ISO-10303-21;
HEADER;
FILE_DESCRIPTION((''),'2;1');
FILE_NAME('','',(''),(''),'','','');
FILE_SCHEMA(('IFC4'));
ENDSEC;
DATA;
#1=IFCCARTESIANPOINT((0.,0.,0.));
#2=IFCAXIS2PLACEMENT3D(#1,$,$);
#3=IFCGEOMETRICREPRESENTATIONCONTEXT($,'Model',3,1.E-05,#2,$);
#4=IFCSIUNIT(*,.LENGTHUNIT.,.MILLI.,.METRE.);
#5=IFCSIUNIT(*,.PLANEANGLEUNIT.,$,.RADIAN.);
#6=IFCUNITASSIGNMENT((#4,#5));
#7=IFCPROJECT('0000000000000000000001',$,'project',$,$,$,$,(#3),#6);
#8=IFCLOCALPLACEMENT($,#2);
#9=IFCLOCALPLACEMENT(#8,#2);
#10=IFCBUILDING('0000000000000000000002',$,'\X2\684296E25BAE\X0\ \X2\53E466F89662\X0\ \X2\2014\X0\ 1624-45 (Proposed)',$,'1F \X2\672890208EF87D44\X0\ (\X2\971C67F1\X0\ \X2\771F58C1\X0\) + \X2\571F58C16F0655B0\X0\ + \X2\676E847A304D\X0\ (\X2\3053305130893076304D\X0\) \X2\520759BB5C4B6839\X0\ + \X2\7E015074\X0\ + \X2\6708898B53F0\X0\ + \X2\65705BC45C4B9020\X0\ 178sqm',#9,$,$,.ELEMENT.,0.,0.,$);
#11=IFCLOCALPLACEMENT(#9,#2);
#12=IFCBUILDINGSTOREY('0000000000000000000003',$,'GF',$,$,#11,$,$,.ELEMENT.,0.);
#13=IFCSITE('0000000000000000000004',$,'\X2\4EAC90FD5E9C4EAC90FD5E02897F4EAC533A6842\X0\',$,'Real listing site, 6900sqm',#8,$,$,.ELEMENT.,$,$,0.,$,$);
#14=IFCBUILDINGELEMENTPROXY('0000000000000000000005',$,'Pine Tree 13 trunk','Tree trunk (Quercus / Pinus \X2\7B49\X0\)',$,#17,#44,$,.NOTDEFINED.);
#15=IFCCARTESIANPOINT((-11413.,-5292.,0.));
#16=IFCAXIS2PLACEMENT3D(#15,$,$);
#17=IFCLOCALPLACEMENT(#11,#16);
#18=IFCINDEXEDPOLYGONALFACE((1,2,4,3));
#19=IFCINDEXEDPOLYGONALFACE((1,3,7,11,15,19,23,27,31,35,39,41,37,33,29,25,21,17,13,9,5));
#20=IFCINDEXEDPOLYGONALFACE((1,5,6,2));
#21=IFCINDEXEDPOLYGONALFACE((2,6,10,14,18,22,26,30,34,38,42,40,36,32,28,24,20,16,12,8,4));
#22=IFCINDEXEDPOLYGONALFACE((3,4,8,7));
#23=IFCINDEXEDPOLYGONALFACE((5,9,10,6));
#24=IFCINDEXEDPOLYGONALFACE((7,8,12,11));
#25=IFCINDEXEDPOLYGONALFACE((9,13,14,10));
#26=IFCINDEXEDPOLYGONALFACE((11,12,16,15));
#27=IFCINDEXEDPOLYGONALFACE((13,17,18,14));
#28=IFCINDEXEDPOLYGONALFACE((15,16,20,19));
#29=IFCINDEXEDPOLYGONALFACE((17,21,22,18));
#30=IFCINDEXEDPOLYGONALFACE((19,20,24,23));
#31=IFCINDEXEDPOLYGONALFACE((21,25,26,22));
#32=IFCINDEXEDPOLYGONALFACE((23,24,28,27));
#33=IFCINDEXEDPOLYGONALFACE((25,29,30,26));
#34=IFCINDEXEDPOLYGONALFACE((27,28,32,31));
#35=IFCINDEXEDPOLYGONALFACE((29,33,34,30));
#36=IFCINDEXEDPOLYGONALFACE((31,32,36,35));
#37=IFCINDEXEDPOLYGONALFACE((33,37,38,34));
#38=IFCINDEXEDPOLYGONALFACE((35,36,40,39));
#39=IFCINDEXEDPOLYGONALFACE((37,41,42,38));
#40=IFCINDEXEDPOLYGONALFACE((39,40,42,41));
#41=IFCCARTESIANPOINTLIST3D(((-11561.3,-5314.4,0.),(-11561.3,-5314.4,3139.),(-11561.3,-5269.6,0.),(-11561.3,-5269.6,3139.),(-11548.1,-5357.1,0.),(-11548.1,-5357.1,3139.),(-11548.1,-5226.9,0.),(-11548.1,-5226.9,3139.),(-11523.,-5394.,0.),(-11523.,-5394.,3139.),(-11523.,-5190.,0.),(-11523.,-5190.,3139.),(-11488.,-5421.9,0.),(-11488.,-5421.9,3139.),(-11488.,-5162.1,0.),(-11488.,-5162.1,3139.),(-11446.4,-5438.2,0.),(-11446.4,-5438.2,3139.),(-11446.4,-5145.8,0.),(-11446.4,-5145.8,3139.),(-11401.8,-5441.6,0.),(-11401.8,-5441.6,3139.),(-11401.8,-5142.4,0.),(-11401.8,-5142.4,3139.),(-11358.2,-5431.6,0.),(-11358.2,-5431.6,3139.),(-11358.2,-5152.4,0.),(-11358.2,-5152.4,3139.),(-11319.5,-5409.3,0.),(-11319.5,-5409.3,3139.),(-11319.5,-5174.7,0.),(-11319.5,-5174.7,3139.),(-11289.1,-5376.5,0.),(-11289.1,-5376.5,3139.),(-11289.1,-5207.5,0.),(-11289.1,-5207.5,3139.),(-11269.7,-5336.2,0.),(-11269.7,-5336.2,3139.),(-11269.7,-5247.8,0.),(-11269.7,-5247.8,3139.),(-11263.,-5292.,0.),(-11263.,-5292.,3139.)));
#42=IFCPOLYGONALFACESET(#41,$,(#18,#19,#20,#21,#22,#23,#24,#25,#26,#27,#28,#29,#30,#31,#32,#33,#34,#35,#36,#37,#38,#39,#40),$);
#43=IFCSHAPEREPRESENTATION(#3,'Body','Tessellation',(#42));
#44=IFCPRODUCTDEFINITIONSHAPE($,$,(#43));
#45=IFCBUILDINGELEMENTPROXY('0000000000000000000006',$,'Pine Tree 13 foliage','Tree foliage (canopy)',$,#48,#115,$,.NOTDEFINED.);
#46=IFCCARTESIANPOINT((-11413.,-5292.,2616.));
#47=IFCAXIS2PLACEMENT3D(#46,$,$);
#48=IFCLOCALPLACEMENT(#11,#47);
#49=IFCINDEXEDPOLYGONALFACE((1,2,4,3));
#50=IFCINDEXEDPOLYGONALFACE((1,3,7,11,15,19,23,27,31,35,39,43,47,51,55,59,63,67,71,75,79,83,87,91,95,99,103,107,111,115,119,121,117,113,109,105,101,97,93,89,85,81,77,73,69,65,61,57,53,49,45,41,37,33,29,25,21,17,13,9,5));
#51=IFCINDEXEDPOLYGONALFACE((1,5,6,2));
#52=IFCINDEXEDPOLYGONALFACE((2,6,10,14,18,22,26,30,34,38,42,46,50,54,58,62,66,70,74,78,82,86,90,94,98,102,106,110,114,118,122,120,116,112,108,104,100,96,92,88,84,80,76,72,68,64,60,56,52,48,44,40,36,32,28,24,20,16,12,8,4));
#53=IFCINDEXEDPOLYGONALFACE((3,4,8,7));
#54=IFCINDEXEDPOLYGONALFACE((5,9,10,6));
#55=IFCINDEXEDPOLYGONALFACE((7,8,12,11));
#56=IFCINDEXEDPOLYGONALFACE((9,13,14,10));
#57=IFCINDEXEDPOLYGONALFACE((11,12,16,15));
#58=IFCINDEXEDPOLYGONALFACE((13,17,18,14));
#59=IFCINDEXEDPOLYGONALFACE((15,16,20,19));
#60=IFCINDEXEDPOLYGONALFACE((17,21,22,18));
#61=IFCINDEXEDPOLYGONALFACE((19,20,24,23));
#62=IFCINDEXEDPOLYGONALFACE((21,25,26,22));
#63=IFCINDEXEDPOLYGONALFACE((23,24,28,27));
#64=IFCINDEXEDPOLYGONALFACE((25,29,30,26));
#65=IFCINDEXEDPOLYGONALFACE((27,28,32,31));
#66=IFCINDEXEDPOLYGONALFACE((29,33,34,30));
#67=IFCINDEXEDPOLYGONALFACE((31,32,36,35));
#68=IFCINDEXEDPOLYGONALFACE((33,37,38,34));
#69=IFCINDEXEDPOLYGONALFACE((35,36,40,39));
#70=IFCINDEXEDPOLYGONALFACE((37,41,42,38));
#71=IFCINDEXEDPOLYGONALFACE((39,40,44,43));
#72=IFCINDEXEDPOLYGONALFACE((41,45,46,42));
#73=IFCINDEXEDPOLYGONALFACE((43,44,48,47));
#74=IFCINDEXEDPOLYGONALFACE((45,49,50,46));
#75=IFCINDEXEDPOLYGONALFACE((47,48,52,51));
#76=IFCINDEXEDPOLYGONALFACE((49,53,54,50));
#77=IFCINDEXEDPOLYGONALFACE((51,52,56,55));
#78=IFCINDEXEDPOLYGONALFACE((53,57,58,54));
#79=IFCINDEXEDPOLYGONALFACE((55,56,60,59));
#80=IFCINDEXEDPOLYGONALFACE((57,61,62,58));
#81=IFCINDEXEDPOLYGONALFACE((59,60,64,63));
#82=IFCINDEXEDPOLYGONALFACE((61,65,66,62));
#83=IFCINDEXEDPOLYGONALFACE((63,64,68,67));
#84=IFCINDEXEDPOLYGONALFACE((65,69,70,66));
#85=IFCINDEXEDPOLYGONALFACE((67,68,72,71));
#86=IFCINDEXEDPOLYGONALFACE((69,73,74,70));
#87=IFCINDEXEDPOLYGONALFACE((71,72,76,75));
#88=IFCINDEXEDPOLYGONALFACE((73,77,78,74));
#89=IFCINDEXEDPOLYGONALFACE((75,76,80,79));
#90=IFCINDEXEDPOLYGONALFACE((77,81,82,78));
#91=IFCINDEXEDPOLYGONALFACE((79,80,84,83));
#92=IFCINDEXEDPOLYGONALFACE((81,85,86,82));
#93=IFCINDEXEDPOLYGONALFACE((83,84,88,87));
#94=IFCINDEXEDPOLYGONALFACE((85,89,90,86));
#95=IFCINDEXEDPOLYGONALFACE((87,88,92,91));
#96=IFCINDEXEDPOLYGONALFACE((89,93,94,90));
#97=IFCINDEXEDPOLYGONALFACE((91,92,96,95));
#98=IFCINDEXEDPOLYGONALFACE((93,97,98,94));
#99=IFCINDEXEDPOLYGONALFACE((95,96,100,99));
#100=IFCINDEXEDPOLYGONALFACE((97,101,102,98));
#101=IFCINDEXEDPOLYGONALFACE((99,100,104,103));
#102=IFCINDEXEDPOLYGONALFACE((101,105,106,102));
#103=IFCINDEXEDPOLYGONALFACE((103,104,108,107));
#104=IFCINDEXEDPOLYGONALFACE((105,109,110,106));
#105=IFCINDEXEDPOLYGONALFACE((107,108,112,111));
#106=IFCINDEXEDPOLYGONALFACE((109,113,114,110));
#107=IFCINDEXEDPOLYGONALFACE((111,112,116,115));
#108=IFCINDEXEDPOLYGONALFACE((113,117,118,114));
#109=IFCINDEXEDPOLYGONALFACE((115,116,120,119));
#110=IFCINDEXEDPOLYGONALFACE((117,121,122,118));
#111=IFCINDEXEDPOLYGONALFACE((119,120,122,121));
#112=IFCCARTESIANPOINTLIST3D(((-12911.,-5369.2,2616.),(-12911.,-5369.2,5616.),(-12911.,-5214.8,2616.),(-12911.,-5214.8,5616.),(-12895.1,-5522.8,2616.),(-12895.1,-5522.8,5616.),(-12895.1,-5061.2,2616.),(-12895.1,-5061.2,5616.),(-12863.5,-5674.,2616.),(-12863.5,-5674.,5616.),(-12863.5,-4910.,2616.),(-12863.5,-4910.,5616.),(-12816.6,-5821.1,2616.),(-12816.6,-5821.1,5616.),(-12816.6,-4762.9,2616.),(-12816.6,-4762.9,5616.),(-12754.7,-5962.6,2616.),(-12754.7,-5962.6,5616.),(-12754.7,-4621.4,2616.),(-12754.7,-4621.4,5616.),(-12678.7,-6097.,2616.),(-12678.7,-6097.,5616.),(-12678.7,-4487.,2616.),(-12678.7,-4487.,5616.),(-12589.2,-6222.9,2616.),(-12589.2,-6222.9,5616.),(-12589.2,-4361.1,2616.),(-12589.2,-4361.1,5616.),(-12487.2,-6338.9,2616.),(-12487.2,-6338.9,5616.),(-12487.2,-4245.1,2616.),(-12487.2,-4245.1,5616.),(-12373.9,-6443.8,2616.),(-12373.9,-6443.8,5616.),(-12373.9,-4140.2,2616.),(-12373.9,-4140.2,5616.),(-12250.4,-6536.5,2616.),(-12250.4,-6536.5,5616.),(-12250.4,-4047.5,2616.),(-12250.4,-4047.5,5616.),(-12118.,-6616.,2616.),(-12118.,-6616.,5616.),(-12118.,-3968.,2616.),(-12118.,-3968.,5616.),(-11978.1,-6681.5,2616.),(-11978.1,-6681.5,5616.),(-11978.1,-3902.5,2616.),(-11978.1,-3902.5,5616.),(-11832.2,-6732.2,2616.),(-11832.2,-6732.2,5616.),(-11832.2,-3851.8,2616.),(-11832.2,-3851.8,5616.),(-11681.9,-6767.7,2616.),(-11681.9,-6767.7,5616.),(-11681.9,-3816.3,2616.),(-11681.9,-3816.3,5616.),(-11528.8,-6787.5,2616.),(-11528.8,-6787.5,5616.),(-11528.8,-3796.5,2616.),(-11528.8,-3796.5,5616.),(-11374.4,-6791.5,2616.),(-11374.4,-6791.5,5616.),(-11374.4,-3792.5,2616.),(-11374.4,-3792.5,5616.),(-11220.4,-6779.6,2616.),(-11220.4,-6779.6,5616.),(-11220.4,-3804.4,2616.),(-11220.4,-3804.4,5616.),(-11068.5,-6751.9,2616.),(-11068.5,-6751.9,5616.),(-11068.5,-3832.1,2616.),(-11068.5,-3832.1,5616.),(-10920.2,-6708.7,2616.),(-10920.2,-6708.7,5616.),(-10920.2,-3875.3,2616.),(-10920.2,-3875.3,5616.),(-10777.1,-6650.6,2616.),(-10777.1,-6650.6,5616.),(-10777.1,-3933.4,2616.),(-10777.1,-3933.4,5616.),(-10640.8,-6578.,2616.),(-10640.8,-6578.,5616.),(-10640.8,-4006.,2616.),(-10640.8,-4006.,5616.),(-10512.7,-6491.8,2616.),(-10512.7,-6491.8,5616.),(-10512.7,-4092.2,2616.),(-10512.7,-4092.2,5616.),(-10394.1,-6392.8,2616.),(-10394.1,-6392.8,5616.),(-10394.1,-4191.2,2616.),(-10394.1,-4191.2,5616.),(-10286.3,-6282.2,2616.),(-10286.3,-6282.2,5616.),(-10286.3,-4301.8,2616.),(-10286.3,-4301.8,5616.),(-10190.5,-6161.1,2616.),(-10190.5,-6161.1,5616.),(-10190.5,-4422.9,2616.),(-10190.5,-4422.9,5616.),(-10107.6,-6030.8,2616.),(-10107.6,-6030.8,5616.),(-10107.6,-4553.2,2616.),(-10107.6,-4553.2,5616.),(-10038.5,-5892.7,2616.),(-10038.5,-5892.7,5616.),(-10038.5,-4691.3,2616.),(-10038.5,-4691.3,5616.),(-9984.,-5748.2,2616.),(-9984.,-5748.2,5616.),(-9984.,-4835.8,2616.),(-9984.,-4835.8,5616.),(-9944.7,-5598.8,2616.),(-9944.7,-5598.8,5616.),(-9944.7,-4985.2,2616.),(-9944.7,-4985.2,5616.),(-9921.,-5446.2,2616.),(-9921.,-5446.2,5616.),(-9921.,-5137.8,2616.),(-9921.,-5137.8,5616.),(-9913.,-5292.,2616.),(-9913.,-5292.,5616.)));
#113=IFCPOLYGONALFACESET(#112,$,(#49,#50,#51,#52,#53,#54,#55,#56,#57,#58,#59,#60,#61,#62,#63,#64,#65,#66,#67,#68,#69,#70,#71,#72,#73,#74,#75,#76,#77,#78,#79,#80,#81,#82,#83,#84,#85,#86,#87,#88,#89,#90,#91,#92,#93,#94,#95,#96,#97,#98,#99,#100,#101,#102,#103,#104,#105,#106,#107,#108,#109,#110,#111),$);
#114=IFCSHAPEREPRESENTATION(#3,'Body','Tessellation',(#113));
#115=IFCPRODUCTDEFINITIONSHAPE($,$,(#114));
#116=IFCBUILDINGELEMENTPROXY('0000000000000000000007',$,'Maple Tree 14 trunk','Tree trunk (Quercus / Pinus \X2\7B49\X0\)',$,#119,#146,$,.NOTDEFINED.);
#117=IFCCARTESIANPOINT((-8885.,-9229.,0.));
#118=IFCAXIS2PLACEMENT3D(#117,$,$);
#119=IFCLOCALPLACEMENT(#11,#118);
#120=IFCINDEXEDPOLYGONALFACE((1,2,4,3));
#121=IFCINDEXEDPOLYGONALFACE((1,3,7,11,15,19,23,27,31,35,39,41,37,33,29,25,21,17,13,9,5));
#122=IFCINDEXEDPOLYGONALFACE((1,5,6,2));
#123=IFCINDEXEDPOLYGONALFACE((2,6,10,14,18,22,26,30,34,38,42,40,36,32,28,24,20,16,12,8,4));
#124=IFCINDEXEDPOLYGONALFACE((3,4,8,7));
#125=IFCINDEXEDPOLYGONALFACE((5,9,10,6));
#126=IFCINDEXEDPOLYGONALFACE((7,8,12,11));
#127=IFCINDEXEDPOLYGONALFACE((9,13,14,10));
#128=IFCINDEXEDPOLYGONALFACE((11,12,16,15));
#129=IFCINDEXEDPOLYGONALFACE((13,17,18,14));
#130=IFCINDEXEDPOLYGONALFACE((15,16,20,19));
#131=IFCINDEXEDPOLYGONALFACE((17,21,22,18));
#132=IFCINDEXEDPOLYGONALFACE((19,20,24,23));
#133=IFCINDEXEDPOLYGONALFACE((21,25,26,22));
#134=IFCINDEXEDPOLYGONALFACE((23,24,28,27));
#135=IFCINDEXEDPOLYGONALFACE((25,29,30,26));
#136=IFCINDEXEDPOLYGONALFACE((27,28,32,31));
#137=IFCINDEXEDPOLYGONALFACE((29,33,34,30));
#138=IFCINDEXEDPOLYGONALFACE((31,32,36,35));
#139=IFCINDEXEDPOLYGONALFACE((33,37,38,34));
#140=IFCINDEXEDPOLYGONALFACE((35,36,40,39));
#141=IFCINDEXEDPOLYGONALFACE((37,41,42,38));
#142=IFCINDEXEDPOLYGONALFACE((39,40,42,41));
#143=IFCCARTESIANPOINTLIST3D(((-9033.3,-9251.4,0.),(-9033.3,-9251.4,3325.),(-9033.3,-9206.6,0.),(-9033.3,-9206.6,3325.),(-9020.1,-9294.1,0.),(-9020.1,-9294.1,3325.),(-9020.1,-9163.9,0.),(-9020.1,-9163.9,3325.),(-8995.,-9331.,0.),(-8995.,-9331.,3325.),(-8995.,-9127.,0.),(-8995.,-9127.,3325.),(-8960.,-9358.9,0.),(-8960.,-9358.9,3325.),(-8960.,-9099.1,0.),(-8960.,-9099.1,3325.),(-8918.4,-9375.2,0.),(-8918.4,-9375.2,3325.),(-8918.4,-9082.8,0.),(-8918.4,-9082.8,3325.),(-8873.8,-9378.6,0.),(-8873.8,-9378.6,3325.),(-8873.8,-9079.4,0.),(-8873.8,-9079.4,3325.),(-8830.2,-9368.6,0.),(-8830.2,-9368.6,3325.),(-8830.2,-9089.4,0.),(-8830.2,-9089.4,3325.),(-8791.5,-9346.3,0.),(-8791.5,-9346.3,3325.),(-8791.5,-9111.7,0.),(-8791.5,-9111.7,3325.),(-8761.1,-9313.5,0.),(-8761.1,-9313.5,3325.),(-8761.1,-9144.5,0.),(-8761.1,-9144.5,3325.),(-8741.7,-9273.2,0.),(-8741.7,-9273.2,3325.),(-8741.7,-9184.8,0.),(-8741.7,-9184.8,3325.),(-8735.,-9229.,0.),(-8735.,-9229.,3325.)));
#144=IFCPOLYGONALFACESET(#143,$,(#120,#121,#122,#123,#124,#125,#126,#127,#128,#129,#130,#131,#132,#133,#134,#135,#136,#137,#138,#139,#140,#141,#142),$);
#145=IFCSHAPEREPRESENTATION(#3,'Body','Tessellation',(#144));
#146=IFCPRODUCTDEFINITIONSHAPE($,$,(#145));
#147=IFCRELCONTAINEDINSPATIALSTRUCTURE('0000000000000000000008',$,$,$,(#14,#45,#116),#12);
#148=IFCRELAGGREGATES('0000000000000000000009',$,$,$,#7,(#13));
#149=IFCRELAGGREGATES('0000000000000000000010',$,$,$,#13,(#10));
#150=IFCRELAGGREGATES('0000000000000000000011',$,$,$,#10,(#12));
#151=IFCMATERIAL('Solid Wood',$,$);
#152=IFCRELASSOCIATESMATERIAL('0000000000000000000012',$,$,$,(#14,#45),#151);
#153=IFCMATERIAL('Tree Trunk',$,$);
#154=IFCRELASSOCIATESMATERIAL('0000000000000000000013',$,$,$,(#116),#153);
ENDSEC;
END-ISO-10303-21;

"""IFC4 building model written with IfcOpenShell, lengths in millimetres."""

from ifc_helpers import new_model, si_unit, frame, origin, origin_2d, place, context, project, spatial, circle, extrude, material, element, save


model = new_model("IFC4")

# Units and contexts
model_context = context("Model", 3, precision=1e-05, world=origin())
ifc_project = project(units=[si_unit("LENGTHUNIT", "METRE", prefix="MILLI"), si_unit("PLANEANGLEUNIT", "RADIAN")], contexts=[model_context])

# Site, building, storey
site_placement = place(None, origin())
site = spatial("IfcSite", under=ifc_project, at=site_placement, Name="京都府京都市西京区桂", ObjectType="Real listing site, 6900sqm", CompositionType="ELEMENT", RefElevation=0.0)
building_placement = place(site_placement, origin())
building = spatial("IfcBuilding", under=site, at=building_placement, Name="桂離宮 古書院 — 1624-45 (Proposed)", ObjectType="1F 木造軸組 (霜柱 真壁) + 土壁漆喰 + 杮葺き (こけらぶき) 切妻屋根 + 縁側 + 月見台 + 数寄屋造 178sqm", CompositionType="ELEMENT", ElevationOfRefHeight=0.0, ElevationOfTerrain=0.0)
storey_placement = place(building_placement, origin())
storey = spatial("IfcBuildingStorey", under=building, at=storey_placement, Name="GF", CompositionType="ELEMENT", Elevation=0.0)

# Shared definitions
ifc_material_1 = material(Name="Solid Wood")

# Building element proxies
proxy_1_placement = place(storey_placement, frame((-11413.0, -5292.0, 0.0)))
element("IfcBuildingElementProxy", 1, at=proxy_1_placement, inside=storey, material=ifc_material_1, Name="Pine Tree 13 trunk", Description="Tree trunk (Quercus / Pinus 等)", PredefinedType="NOTDEFINED", context=model_context, shape_type="SweptSolid", body=[
    extrude(circle(Radius=150.0, at=origin_2d()), frame((-11413.0, -5292.0, 0.0)), (0.0, 0.0, 1.0), 3139.0),
])
proxy_2_placement = place(storey_placement, frame((-11413.0, -5292.0, 2616.0)))
element("IfcBuildingElementProxy", 2, at=proxy_2_placement, inside=storey, material=ifc_material_1, Name="Pine Tree 13 foliage", Description="Tree foliage (canopy)", PredefinedType="NOTDEFINED", context=model_context, shape_type="SweptSolid", body=[
    extrude(circle(Radius=1500.0, at=origin_2d()), frame((-11413.0, -5292.0, 2616.0)), (0.0, 0.0, 1.0), 3000.0),
])
ifc_material_2 = material(Name="Tree Trunk")
proxy_3_placement = place(storey_placement, frame((-8885.0, -9229.0, 0.0)))
element("IfcBuildingElementProxy", 3, at=proxy_3_placement, inside=storey, material=ifc_material_2, Name="Maple Tree 14 trunk", Description="Tree trunk (Quercus / Pinus 等)", PredefinedType="NOTDEFINED", context=model_context, shape_type="SweptSolid", body=[
    extrude(circle(Radius=150.0, at=origin_2d()), frame((-8885.0, -9229.0, 0.0)), (0.0, 0.0, 1.0), 3325.0),
])

save(model, "model.ifc")
